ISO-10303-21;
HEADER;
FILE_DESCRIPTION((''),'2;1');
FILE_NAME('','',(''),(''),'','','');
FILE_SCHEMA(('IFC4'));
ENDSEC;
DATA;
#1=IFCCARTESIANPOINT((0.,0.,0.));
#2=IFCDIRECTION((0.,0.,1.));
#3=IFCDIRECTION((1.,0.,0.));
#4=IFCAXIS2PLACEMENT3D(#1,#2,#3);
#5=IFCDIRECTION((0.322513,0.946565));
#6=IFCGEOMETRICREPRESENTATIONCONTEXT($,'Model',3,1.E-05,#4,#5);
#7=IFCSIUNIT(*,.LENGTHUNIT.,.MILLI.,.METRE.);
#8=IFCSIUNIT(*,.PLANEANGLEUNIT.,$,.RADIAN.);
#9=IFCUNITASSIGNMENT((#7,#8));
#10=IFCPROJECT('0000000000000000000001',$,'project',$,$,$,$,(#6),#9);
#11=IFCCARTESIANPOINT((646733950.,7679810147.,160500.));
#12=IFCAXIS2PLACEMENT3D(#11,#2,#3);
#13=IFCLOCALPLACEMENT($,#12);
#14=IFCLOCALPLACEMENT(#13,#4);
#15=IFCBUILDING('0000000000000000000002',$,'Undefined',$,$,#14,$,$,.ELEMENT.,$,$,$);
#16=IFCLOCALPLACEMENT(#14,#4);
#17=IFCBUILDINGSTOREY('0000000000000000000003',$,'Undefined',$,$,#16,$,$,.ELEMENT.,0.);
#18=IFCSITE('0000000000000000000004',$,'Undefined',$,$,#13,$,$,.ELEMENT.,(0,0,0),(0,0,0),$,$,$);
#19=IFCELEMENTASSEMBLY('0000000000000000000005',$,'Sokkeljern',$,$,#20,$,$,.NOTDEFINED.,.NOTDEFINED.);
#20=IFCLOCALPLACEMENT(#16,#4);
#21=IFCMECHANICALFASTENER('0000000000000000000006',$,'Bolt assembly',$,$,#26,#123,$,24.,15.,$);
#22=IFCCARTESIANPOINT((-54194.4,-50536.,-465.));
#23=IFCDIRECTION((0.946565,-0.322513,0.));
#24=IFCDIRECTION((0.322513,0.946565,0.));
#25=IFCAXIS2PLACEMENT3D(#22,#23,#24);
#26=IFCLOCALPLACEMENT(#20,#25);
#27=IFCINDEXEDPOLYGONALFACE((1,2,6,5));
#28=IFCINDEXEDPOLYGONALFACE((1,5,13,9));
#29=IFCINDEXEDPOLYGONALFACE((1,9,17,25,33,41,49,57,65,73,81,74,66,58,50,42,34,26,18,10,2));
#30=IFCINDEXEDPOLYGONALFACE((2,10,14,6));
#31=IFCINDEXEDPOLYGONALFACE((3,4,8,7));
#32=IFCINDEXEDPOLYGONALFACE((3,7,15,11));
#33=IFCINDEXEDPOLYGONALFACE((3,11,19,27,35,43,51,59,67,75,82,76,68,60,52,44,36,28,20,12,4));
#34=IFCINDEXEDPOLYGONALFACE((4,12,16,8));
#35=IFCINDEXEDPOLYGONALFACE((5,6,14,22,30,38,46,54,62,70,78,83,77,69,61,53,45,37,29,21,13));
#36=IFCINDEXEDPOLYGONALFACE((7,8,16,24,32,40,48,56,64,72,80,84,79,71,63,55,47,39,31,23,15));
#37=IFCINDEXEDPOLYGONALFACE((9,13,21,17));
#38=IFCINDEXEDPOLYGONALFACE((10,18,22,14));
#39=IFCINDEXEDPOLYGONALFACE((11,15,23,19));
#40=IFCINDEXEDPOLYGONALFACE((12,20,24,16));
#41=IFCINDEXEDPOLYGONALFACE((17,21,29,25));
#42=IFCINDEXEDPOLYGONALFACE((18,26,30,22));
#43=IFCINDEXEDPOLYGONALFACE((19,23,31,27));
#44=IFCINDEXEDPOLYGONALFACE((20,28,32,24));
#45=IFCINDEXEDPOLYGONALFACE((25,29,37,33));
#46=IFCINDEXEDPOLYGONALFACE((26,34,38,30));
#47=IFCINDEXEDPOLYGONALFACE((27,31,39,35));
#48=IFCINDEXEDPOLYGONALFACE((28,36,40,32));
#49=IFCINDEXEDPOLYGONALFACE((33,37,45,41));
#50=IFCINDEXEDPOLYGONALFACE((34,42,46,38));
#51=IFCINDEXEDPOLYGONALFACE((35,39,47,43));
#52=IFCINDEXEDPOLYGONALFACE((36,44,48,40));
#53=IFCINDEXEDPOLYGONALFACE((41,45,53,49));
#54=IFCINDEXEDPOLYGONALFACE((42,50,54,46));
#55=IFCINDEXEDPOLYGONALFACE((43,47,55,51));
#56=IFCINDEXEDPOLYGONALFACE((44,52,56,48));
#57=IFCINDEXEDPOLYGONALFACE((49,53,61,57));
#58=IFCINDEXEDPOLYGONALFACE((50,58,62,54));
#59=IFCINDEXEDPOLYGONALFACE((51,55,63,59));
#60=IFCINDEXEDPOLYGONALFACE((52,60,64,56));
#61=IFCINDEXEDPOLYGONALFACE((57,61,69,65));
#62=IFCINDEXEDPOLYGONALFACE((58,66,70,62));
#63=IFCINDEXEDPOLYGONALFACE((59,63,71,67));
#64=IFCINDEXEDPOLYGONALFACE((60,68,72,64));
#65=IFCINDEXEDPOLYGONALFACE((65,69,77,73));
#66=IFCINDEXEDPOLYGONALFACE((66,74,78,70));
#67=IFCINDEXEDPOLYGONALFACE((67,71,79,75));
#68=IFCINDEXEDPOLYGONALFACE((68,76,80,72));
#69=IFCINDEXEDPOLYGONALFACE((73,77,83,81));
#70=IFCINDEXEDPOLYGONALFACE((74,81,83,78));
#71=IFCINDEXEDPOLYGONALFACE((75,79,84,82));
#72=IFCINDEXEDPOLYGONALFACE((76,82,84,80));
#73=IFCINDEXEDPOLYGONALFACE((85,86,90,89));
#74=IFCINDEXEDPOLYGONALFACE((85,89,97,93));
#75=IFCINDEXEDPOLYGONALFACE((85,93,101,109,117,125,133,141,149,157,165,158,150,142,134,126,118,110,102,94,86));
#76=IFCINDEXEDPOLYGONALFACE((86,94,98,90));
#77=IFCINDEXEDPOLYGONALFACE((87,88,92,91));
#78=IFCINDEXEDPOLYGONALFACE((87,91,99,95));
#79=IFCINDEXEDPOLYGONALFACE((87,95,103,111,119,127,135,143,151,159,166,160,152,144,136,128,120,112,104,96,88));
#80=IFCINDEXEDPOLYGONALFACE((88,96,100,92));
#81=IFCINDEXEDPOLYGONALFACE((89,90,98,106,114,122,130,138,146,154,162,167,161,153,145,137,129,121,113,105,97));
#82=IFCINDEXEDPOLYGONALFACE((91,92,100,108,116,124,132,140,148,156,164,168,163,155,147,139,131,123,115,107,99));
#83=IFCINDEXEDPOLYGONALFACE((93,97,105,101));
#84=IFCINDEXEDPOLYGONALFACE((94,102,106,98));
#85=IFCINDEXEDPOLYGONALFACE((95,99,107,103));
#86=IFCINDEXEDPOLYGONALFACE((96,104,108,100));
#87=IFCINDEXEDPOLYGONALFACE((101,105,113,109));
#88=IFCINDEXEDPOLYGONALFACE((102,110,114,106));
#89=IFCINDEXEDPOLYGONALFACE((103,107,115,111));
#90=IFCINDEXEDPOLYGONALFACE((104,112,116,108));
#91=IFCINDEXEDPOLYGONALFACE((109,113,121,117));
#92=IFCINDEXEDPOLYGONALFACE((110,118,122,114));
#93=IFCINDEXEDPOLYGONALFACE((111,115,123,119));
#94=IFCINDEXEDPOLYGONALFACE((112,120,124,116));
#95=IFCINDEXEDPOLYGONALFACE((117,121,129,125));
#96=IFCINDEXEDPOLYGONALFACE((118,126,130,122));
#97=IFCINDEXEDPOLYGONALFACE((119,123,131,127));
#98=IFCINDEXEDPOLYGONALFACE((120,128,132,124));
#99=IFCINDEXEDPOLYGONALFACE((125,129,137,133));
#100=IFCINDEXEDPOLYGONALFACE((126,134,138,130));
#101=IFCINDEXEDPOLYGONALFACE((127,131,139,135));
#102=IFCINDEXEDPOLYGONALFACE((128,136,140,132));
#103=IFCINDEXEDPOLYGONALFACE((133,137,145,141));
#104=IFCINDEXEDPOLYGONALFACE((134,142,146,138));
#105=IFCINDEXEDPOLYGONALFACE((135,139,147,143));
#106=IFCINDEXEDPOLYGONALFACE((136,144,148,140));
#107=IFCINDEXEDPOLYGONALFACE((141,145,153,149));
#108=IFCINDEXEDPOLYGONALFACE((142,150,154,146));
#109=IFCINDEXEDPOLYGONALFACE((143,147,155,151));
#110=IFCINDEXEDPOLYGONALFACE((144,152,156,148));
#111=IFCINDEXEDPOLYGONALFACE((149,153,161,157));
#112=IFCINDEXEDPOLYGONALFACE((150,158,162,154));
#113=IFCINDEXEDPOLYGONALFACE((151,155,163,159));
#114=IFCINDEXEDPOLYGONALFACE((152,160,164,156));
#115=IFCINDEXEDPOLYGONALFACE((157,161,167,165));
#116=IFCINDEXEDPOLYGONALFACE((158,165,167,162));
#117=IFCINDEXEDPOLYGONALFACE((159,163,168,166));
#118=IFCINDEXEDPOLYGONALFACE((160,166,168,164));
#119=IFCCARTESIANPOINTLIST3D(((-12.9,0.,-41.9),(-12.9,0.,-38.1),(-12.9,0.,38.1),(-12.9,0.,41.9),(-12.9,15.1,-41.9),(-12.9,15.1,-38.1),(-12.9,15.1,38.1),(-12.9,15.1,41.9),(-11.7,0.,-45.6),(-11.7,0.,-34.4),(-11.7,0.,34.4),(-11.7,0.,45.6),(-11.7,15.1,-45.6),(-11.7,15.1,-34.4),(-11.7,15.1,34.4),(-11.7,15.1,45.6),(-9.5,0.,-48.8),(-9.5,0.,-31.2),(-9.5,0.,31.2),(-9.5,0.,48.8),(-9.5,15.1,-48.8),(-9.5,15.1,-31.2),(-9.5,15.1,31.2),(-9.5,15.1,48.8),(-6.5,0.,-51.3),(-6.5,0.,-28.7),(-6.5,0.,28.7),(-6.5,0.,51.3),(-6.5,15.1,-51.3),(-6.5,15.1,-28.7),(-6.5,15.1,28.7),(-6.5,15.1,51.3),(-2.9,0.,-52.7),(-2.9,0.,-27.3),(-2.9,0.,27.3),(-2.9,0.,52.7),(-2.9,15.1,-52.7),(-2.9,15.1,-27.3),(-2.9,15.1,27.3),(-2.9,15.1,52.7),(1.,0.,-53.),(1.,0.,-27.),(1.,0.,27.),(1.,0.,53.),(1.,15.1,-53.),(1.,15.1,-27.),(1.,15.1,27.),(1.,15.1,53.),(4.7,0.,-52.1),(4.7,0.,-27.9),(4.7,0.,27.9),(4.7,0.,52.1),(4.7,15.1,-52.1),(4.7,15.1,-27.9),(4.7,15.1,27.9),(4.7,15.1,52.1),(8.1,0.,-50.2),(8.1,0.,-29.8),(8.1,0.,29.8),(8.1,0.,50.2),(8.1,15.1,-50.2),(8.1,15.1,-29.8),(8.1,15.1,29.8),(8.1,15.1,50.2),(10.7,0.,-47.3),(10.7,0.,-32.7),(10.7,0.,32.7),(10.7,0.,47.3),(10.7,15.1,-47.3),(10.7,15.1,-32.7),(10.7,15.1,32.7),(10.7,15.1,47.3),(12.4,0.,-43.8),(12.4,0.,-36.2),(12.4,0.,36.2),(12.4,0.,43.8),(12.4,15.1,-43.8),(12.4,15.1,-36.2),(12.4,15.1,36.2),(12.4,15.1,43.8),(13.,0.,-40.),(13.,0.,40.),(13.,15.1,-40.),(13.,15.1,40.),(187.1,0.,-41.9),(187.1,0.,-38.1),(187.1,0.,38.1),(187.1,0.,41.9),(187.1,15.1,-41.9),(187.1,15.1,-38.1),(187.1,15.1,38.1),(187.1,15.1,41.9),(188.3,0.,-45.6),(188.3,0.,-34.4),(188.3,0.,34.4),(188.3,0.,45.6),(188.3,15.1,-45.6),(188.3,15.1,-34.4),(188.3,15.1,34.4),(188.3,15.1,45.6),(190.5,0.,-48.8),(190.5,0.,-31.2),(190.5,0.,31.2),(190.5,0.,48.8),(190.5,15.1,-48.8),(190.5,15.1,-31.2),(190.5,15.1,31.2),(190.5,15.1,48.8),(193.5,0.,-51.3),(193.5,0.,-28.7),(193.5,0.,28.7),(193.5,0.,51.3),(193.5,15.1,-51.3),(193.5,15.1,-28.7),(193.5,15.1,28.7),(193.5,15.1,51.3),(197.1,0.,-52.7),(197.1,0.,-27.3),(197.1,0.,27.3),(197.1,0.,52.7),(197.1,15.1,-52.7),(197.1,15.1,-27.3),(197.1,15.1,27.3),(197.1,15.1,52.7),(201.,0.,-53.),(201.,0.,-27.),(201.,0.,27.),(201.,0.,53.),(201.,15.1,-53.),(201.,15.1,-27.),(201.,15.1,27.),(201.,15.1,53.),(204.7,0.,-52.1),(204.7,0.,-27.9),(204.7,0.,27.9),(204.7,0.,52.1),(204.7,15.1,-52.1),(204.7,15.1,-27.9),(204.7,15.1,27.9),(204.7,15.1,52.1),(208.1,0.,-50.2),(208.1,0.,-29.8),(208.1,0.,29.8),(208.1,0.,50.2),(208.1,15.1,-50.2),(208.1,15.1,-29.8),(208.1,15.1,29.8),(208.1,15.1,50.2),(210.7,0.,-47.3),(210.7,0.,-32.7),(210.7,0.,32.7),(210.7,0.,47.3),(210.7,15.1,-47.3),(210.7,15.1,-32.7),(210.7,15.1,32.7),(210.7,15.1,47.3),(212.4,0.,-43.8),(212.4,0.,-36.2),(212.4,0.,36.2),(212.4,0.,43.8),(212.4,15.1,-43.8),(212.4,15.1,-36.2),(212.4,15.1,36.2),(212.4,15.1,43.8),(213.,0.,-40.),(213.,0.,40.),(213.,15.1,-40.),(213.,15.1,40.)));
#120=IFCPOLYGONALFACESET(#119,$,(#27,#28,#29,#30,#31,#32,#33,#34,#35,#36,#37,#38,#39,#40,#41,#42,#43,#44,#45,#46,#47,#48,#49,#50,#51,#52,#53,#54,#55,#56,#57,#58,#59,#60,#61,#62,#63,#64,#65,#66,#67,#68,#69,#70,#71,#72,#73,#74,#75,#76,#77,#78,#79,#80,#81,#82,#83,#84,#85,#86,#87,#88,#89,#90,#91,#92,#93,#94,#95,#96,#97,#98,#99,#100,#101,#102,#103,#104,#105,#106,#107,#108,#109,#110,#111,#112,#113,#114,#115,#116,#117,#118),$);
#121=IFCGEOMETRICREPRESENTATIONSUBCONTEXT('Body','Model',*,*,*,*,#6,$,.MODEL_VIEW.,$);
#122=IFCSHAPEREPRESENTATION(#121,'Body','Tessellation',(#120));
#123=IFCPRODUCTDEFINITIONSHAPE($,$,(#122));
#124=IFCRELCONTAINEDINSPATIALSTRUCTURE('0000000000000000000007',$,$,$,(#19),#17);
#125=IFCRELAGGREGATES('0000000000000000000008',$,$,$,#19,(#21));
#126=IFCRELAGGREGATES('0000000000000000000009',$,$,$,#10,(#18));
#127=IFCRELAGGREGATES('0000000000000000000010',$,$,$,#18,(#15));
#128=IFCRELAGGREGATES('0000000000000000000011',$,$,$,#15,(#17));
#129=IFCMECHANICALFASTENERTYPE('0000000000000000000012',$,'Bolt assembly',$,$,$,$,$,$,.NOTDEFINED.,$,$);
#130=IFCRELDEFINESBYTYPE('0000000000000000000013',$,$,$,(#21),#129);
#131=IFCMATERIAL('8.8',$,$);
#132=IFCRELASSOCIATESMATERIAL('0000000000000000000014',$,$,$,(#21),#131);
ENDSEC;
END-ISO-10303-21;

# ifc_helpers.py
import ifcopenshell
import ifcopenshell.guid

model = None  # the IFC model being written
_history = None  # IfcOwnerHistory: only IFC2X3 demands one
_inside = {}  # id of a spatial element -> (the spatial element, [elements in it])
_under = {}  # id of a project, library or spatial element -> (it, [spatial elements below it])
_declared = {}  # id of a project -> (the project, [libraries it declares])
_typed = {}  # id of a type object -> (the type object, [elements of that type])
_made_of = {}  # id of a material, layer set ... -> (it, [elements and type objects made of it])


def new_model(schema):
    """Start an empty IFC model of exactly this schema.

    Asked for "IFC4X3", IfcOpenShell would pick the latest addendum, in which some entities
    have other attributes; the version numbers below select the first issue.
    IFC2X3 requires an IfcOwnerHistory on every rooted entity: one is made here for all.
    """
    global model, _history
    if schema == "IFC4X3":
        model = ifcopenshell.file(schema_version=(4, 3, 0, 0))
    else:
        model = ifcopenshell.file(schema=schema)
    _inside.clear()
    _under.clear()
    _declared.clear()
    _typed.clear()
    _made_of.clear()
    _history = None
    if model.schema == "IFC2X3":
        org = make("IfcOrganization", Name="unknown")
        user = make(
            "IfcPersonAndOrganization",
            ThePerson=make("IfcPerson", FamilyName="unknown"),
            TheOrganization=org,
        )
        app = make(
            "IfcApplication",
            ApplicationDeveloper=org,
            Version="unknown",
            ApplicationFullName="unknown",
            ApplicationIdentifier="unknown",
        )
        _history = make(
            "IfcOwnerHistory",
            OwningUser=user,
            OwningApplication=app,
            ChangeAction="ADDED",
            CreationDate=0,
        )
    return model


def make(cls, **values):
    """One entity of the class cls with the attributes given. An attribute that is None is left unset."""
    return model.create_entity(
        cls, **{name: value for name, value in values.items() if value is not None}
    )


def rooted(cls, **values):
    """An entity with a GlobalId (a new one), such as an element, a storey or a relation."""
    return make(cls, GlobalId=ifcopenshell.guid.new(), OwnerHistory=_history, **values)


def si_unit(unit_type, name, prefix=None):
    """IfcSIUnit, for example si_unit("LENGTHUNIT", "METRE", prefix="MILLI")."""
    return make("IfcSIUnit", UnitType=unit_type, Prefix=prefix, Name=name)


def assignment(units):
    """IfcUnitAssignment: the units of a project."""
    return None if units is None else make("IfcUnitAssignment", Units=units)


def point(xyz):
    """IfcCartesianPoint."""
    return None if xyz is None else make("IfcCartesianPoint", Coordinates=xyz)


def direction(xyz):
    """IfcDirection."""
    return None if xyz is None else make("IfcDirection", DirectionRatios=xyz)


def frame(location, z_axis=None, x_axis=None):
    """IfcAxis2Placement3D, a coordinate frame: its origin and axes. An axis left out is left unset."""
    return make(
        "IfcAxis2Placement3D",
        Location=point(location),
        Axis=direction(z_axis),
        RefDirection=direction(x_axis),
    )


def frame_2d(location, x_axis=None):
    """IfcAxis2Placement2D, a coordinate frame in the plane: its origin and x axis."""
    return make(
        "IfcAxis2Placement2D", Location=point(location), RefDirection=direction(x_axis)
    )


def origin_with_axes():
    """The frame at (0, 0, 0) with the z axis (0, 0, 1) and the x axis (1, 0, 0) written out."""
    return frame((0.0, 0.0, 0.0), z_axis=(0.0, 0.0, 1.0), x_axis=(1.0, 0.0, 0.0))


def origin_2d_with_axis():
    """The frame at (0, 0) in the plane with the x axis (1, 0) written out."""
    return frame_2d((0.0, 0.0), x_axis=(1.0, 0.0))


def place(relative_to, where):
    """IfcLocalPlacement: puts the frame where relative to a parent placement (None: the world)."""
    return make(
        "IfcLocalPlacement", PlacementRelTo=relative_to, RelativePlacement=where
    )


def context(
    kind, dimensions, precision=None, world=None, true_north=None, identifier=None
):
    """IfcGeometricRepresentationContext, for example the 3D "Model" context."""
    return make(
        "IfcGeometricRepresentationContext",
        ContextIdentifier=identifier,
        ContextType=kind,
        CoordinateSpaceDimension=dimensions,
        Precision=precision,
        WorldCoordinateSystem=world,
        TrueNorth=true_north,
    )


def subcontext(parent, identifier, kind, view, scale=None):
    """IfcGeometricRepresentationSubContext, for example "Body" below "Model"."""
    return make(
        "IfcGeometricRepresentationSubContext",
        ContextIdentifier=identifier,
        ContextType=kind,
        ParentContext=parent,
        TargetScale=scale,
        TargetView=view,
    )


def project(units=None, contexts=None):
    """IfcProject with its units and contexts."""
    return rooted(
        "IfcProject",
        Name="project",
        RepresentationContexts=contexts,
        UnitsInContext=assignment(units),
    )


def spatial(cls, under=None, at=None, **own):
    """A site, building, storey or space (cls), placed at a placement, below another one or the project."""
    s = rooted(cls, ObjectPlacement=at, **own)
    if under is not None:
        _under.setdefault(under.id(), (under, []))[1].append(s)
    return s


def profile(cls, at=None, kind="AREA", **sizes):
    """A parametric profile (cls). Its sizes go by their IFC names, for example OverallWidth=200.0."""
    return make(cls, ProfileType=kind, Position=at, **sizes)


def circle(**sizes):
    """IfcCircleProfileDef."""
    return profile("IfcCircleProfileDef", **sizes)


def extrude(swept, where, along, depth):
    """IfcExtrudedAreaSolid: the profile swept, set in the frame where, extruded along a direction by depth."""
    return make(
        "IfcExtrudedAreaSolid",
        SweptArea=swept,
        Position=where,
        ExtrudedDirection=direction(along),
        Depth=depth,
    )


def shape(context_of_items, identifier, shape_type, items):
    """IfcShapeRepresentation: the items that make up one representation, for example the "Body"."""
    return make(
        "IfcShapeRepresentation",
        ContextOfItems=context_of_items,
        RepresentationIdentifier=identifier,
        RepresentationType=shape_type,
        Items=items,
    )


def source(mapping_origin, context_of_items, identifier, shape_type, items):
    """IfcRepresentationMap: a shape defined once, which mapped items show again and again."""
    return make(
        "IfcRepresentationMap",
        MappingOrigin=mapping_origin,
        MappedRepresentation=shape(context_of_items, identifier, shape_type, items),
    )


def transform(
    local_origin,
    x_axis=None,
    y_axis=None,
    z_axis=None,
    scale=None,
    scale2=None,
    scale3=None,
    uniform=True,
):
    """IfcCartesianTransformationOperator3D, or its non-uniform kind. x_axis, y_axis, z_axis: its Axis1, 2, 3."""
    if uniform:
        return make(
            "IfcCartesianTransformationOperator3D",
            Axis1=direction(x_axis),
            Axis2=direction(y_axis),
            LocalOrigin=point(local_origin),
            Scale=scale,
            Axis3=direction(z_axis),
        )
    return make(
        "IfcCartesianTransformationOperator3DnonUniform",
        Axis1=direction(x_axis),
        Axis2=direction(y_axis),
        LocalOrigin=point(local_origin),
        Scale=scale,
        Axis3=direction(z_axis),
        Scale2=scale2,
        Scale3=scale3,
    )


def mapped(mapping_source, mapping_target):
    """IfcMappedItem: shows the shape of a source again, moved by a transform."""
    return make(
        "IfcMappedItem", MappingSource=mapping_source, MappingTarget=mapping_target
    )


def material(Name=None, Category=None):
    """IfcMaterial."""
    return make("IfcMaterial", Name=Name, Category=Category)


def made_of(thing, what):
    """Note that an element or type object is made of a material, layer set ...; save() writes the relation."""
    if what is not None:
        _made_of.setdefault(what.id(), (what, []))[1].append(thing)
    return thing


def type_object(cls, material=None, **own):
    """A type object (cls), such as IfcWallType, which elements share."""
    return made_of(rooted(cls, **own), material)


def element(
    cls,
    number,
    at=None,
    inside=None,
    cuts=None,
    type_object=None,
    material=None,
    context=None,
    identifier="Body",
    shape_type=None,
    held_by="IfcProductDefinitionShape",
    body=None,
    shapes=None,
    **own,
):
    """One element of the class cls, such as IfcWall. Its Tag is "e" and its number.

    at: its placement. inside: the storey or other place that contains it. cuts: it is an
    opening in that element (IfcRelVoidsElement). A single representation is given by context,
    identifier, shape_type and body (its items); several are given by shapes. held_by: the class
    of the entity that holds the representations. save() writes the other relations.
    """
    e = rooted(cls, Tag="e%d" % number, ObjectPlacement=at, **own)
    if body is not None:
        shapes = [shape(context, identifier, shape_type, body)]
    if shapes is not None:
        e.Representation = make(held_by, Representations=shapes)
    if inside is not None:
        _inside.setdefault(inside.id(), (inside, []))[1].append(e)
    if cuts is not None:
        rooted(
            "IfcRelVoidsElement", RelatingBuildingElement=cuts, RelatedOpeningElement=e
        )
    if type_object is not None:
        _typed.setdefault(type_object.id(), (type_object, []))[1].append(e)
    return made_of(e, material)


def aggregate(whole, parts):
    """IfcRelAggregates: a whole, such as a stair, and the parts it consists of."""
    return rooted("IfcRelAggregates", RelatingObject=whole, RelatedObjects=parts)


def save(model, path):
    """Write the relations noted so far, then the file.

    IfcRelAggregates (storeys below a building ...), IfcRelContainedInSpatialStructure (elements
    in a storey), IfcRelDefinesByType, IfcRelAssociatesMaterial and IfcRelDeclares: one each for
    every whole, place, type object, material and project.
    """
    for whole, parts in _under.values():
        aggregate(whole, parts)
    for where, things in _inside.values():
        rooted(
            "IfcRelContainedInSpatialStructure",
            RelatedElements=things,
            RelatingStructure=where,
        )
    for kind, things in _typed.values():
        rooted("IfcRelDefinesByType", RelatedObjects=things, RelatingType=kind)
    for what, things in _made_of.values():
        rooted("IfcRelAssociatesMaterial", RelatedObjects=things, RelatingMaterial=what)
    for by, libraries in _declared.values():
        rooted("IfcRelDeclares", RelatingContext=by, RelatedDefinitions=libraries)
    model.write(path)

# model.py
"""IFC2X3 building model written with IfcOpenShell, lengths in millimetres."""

from ifc_helpers import new_model, si_unit, direction, frame, origin_with_axes, origin_2d_with_axis, place, context, subcontext, project, spatial, circle, extrude, source, transform, mapped, material, type_object, element, aggregate, save


model = new_model("IFC2X3")

# Units and contexts
model_context = context("Model", 3, precision=1e-05, world=origin_with_axes(), true_north=direction((0.322513, 0.946565)))
body_context = subcontext(model_context, "Body", "Model", "MODEL_VIEW")
ifc_project = project(units=[si_unit("LENGTHUNIT", "METRE", prefix="MILLI"), si_unit("PLANEANGLEUNIT", "RADIAN")], contexts=[model_context])

# Site, building, storey
site_placement = place(None, frame((646733950.0, 7679810147.0, 160500.0), z_axis=(0.0, 0.0, 1.0), x_axis=(1.0, 0.0, 0.0)))
site = spatial("IfcSite", under=ifc_project, at=site_placement, Name="Undefined", CompositionType="ELEMENT", RefLatitude=(0, 0, 0), RefLongitude=(0, 0, 0))
building_placement = place(site_placement, origin_with_axes())
building = spatial("IfcBuilding", under=site, at=building_placement, Name="Undefined", CompositionType="ELEMENT")
storey_placement = place(building_placement, origin_with_axes())
storey = spatial("IfcBuildingStorey", under=building, at=storey_placement, Name="Undefined", CompositionType="ELEMENT", Elevation=0.0)

# Element assembly
assembly_1_placement = place(storey_placement, origin_with_axes())
assembly_1 = element("IfcElementAssembly", 1, at=assembly_1_placement, inside=storey, Name="Sokkeljern", AssemblyPlace="NOTDEFINED", PredefinedType="NOTDEFINED")

# Mechanical fastener
ifc_material_1 = material(Name="8.8")
mechanical_fastener_type = type_object("IfcMechanicalFastenerType", Name="Bolt assembly")
shared_shape_1 = source(origin_with_axes(), body_context, "Body", "SweptSolid", [
    extrude(circle(Radius=13.0, at=origin_2d_with_axis()), frame((0.0, 0.0, 0.0), z_axis=(0.0, 1.0, 0.0), x_axis=(1.0, 0.0, 0.0)), (0.0, 0.0, 1.0), 15.1),
])
mechanical_fastener_1_placement = place(assembly_1_placement, frame((-54194.4, -50536.0, -465.0), z_axis=(0.946565, -0.322513, 0.0), x_axis=(0.322513, 0.946565, 0.0)))
mechanical_fastener_1 = element("IfcMechanicalFastener", 2, at=mechanical_fastener_1_placement, type_object=mechanical_fastener_type, material=ifc_material_1, Name="Bolt assembly", NominalDiameter=24.0, NominalLength=15.0, context=body_context, shape_type="MappedRepresentation", body=[
    mapped(shared_shape_1, transform((0.0, 0.0, -40.0))),
    mapped(shared_shape_1, transform((200.0, 0.0, -40.0))),
    mapped(shared_shape_1, transform((0.0, 0.0, 40.0))),
    mapped(shared_shape_1, transform((200.0, 0.0, 40.0))),
])
aggregate(assembly_1, [mechanical_fastener_1])

save(model, "model.ifc")
